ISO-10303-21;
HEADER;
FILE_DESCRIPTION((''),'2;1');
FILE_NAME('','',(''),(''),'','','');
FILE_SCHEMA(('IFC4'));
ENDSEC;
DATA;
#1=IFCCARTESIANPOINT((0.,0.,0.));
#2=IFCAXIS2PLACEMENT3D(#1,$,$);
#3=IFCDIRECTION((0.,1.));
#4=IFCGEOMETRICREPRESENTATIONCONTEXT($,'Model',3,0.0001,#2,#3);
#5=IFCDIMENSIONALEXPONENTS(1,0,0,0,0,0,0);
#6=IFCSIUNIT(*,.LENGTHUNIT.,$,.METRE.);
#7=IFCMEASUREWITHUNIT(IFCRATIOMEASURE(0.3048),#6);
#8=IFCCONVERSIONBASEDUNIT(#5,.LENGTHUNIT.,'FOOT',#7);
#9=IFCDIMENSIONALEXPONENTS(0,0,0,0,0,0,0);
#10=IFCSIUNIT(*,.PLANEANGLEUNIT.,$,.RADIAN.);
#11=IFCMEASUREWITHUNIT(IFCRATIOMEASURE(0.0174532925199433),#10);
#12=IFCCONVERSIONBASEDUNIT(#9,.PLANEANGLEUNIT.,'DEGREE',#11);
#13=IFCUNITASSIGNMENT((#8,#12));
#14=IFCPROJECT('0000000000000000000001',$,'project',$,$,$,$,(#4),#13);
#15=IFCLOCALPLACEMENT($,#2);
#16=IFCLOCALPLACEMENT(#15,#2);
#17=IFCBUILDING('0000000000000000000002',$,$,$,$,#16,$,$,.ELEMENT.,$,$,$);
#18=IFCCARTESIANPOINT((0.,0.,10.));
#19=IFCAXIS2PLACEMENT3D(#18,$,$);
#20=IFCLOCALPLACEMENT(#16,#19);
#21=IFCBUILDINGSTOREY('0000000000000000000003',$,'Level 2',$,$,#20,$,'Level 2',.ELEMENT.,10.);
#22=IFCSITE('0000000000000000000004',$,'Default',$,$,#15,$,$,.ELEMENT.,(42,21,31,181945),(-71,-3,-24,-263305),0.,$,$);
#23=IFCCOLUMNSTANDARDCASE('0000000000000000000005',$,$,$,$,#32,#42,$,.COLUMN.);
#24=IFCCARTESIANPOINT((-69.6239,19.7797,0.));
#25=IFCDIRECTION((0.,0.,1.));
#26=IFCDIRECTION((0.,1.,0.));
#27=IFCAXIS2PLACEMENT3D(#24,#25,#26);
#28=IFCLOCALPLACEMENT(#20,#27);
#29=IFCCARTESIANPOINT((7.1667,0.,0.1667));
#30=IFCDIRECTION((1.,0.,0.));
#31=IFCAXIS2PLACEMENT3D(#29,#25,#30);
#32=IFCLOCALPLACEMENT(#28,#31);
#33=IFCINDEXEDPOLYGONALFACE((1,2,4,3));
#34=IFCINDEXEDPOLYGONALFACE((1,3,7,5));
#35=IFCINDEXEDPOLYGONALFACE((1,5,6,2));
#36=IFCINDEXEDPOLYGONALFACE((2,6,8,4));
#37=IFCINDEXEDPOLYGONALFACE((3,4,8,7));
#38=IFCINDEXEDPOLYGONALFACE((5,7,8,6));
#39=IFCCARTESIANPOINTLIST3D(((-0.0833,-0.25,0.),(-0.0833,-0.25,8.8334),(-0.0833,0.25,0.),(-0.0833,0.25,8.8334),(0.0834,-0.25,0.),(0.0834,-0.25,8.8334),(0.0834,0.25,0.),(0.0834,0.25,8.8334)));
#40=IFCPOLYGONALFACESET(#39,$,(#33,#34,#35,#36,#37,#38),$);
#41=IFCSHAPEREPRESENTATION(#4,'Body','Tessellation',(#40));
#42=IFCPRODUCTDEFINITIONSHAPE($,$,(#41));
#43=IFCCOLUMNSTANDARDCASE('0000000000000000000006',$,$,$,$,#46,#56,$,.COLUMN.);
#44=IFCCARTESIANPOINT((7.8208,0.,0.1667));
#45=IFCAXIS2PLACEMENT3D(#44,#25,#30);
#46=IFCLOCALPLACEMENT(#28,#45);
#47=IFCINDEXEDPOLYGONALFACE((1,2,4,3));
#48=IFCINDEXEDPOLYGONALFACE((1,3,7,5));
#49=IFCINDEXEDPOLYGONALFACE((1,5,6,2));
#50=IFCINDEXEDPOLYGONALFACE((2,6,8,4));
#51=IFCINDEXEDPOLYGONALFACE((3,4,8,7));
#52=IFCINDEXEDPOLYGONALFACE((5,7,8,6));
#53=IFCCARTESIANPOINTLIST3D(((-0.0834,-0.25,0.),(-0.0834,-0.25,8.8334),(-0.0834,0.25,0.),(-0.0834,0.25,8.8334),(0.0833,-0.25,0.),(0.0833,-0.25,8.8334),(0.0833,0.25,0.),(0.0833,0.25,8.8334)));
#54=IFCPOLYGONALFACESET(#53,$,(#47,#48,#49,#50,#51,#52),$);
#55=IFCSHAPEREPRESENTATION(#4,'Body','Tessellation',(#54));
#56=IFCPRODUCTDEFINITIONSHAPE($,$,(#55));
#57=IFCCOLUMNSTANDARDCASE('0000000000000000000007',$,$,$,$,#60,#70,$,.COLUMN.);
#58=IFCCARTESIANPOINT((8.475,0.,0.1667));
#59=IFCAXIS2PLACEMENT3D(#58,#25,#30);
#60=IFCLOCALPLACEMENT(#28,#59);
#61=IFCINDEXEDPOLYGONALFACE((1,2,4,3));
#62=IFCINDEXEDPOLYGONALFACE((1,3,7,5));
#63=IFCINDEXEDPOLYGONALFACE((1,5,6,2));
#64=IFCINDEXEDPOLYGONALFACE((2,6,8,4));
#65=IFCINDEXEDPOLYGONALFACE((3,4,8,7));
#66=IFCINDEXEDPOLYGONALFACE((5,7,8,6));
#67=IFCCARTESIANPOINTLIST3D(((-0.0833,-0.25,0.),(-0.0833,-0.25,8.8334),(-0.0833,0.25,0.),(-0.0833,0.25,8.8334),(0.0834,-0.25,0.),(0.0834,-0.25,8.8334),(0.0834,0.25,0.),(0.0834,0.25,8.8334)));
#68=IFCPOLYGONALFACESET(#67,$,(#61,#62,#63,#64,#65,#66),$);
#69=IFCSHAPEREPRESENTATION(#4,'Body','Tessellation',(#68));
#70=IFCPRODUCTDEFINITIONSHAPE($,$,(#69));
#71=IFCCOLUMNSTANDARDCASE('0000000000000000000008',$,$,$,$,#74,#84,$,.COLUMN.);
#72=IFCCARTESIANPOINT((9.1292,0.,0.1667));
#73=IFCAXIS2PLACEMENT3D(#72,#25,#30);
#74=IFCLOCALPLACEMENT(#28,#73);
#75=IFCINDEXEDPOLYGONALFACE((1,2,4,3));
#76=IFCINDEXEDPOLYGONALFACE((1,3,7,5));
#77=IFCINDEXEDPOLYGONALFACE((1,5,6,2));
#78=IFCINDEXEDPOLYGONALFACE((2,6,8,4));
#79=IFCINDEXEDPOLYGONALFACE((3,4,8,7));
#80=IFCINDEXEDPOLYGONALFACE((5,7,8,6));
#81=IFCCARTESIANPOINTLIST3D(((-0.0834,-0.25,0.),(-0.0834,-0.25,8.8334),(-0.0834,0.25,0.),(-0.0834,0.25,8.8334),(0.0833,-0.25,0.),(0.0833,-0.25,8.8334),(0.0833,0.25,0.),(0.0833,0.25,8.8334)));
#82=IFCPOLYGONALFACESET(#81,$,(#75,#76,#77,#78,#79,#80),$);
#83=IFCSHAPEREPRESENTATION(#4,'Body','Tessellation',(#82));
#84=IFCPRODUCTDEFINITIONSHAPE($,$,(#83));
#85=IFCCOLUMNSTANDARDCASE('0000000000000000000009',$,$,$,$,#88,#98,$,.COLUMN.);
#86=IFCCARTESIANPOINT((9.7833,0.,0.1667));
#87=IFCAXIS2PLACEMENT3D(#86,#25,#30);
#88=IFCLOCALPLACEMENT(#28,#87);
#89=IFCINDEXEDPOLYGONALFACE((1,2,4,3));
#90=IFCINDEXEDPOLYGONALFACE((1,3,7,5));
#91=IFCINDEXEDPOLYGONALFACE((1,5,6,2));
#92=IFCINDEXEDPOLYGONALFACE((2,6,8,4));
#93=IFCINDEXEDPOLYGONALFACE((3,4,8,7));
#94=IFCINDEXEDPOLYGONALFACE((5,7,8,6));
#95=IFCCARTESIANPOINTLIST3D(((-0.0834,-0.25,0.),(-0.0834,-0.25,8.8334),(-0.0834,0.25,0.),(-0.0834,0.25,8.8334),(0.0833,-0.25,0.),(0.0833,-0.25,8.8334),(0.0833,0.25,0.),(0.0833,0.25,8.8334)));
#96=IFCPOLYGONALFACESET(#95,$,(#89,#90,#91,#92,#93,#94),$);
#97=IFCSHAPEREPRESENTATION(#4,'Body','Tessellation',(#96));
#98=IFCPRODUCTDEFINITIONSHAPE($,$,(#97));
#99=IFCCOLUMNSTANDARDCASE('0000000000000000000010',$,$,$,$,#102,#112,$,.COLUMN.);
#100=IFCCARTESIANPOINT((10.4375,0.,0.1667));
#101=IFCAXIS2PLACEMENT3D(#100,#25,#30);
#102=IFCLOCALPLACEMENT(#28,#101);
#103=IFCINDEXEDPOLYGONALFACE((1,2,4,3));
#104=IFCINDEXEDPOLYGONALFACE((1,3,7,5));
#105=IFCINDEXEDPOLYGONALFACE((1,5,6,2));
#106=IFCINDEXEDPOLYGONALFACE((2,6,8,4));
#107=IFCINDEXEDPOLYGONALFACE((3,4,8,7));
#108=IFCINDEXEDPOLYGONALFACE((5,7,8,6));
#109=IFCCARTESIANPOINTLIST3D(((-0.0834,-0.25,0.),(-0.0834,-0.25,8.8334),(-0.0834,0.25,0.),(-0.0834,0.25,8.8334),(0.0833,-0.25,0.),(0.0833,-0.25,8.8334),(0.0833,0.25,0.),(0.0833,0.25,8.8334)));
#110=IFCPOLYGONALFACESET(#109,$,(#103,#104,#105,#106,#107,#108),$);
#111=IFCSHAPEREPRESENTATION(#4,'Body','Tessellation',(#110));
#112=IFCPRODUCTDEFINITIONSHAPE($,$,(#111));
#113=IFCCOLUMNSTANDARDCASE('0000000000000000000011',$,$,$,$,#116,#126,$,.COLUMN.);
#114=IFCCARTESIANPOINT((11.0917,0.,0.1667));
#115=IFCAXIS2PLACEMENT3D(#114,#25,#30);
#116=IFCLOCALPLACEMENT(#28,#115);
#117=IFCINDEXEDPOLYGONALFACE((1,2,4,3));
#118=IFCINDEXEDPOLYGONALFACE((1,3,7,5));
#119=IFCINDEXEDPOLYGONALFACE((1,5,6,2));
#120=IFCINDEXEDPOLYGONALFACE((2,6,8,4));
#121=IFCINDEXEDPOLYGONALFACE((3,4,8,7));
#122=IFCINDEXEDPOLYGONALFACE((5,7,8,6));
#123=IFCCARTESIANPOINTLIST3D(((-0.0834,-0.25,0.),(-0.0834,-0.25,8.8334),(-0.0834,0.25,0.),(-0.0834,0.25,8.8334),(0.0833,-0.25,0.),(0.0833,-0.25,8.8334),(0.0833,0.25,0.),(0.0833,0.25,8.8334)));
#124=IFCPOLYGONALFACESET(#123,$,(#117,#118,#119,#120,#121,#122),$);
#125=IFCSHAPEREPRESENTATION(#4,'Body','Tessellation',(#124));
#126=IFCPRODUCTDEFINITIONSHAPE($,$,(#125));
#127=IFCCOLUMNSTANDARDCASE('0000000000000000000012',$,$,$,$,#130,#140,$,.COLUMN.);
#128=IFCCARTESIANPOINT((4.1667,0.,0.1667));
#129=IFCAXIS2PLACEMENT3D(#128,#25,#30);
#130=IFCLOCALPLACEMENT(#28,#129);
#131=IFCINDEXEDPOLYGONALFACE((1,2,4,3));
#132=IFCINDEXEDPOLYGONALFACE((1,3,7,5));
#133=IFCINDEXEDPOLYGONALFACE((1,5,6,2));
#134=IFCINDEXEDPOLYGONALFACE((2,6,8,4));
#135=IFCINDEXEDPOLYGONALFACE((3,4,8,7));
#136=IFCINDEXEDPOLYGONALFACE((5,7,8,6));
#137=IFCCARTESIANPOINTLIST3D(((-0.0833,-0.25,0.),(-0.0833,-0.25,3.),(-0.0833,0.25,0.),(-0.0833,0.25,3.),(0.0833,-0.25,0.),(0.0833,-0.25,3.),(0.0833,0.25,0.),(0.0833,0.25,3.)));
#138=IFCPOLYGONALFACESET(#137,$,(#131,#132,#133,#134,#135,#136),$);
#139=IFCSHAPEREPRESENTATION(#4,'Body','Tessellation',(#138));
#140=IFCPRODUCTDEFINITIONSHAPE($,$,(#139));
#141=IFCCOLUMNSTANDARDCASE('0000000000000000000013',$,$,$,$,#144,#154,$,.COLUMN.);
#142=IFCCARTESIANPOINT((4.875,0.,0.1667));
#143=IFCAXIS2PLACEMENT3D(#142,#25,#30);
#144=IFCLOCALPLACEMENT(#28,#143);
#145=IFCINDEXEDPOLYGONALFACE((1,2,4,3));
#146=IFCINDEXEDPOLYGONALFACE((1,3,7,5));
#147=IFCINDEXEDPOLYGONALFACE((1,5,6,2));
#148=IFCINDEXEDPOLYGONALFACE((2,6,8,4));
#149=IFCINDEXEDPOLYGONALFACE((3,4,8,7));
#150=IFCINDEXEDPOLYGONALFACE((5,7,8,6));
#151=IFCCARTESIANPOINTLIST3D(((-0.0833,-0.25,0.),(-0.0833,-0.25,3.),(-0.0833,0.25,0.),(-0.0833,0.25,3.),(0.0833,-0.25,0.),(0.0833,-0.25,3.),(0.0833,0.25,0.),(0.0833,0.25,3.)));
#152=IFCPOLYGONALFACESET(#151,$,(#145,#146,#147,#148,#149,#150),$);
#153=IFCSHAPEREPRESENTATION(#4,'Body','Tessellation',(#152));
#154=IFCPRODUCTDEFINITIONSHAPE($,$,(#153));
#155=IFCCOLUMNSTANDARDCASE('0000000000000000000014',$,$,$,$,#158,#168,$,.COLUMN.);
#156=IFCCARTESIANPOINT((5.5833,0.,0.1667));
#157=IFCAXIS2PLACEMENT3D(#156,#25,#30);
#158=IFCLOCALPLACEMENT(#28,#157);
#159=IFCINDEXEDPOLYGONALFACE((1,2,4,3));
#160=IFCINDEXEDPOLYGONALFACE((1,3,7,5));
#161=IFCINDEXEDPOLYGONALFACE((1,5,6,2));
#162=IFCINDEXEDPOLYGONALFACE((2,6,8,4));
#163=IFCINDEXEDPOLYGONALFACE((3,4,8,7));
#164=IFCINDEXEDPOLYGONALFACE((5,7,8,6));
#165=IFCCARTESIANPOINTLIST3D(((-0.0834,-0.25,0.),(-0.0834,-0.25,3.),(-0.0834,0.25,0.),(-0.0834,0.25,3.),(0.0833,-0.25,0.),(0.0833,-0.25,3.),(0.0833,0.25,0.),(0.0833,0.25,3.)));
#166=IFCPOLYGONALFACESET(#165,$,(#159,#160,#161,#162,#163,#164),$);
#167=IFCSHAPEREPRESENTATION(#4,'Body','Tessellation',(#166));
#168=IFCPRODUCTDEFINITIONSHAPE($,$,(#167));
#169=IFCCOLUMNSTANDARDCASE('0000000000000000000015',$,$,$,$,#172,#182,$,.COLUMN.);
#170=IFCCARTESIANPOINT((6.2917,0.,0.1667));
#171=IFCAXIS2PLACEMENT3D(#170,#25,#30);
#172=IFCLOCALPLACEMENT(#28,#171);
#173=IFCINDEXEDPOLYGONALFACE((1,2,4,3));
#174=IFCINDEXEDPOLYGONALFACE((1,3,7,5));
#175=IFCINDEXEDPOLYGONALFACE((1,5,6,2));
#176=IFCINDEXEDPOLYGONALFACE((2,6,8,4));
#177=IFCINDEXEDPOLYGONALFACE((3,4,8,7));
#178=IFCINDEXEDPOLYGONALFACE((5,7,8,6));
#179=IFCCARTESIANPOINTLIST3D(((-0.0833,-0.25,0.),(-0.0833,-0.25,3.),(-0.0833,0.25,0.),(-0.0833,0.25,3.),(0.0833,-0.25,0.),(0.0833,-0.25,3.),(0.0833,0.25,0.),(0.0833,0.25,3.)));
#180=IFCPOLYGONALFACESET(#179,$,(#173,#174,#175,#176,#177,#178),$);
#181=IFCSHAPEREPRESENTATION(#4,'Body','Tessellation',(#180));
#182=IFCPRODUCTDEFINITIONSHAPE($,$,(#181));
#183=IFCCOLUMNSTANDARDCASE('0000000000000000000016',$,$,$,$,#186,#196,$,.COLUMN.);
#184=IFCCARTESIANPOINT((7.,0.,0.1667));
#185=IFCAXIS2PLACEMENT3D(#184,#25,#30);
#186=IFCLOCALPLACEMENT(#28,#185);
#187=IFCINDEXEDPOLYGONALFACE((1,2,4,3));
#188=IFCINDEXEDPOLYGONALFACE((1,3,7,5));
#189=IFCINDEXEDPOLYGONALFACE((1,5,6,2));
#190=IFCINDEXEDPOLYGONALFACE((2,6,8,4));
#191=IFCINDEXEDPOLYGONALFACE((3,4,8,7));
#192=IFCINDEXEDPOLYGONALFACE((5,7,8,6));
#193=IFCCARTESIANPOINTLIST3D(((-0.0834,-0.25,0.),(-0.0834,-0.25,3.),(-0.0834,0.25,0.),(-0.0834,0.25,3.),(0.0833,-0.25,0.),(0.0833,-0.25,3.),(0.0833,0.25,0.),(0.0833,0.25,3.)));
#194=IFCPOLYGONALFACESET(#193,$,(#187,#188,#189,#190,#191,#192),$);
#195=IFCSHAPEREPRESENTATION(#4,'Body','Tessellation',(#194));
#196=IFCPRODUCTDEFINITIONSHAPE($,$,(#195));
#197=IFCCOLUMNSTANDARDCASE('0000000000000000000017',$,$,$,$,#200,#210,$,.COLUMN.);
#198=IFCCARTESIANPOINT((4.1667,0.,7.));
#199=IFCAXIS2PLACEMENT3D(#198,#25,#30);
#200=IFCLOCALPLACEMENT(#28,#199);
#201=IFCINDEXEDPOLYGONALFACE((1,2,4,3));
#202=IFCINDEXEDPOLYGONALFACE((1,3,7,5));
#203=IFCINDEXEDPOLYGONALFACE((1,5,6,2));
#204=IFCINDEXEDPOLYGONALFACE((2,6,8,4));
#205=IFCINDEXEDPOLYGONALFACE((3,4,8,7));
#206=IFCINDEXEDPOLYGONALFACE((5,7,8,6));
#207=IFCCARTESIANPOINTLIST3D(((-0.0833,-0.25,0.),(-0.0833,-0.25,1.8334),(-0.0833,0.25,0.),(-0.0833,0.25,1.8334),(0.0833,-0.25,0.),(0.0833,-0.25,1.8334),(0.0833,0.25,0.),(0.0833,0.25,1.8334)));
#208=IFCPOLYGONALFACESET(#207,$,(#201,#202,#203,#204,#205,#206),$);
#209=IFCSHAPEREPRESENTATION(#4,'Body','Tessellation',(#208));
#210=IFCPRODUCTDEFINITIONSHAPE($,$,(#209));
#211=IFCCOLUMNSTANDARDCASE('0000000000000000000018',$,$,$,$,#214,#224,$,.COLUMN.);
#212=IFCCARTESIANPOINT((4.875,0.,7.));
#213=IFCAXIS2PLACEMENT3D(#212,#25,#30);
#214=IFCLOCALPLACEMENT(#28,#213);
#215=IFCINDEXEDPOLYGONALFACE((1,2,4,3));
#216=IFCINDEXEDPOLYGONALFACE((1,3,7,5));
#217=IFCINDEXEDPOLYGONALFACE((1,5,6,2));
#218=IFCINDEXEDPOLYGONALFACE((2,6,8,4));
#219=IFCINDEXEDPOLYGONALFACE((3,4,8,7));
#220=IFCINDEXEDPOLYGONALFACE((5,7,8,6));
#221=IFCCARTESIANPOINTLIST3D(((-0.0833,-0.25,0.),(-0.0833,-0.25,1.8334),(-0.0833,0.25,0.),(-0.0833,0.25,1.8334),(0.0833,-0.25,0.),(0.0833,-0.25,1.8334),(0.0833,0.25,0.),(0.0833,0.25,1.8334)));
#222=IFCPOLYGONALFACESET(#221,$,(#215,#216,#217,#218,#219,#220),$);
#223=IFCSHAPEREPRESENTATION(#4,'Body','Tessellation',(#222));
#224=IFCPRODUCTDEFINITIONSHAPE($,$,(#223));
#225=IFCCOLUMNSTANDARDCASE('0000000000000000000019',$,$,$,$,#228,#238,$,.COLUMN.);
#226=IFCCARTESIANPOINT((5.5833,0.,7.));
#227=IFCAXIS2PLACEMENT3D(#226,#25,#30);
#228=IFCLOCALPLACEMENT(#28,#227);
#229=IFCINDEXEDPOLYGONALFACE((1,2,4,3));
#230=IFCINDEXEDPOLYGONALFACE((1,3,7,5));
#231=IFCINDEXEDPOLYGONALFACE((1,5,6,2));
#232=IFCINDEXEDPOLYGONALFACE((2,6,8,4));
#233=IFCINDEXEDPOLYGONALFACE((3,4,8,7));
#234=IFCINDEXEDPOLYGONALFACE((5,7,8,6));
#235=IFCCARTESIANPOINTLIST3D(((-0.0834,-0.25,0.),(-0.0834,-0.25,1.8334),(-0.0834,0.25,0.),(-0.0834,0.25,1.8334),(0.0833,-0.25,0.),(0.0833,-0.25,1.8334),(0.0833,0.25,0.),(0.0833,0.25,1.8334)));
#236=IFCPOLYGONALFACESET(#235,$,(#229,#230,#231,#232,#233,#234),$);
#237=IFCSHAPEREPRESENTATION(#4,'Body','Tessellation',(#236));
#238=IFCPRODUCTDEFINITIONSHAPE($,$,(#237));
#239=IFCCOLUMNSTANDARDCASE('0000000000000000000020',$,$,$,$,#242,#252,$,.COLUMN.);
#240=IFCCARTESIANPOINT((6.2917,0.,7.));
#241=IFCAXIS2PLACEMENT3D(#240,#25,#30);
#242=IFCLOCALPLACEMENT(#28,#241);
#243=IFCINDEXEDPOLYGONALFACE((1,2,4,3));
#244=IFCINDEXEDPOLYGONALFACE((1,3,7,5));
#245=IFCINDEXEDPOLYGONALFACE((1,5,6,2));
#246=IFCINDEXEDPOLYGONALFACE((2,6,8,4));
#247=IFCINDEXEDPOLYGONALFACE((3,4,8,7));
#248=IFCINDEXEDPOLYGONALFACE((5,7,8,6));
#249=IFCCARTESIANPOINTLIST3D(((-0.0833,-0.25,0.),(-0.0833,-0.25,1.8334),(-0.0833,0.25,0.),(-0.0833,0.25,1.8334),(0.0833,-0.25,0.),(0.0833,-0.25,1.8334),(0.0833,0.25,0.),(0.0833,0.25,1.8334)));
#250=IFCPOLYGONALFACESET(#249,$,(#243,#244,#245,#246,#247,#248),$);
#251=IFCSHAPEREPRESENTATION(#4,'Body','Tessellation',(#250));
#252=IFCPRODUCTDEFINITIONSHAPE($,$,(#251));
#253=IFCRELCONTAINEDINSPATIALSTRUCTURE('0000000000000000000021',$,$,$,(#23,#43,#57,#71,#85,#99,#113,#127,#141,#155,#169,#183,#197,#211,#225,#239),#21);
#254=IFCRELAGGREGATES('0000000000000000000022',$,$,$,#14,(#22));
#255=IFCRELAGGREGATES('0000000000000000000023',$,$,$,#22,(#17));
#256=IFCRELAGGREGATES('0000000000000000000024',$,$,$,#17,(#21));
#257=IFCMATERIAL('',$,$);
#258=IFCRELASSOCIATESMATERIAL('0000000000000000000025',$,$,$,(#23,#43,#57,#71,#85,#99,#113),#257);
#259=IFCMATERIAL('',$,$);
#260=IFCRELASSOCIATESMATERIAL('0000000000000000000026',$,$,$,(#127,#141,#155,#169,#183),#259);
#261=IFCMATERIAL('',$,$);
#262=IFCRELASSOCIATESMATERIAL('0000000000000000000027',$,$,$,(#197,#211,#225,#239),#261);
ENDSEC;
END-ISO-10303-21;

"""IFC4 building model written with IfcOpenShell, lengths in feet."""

from ifc_helpers import new_model, entity, si_unit, converted_unit, direction, frame, origin, place, context, project, spatial, rectangle, extrude, material, element, save


model = new_model("IFC4")

# Units and contexts
model_context = context("Model", 3, precision=0.0001, world=origin(), true_north=direction((0.0, 1.0)))
ifc_project = project(units=[converted_unit("LENGTHUNIT", "FOOT", entity("IfcRatioMeasure", 0.3048), si_unit("LENGTHUNIT", "METRE"), dimensions=[1, 0, 0, 0, 0, 0, 0]), converted_unit("PLANEANGLEUNIT", "DEGREE", entity("IfcRatioMeasure", 0.0174532925199433), si_unit("PLANEANGLEUNIT", "RADIAN"), dimensions=[0, 0, 0, 0, 0, 0, 0])], contexts=[model_context])

# Site, building, storey
site_placement = place(None, origin())
site = spatial("IfcSite", under=ifc_project, at=site_placement, Name="Default", CompositionType="ELEMENT", RefLatitude=(42, 21, 31, 181945), RefLongitude=(-71, -3, -24, -263305), RefElevation=0.0)
building_placement = place(site_placement, origin())
building = spatial("IfcBuilding", under=site, at=building_placement, CompositionType="ELEMENT")
storey_placement = place(building_placement, frame((0.0, 0.0, 10.0)))
storey = spatial("IfcBuildingStorey", under=building, at=storey_placement, Name="Level 2", LongName="Level 2", CompositionType="ELEMENT", Elevation=10.0)

# Columns
placement_1 = place(storey_placement, frame((-69.6239, 19.7797, 0.0), z_axis=(0.0, 0.0, 1.0), x_axis=(0.0, 1.0, 0.0)))
ifc_material_1 = material(Name="")
for number, where, z_axis, x_axis in (
    (1, (7.1667, 0.0, 0.1667), (0.0, 0.0, 1.0), (1.0, 0.0, 0.0)),
    (2, (7.8208, 0.0, 0.1667), (0.0, 0.0, 1.0), (1.0, 0.0, 0.0)),
    (3, (8.475, 0.0, 0.1667), (0.0, 0.0, 1.0), (1.0, 0.0, 0.0)),
    (4, (9.1292, 0.0, 0.1667), (0.0, 0.0, 1.0), (1.0, 0.0, 0.0)),
    (5, (9.7833, 0.0, 0.1667), (0.0, 0.0, 1.0), (1.0, 0.0, 0.0)),
    (6, (10.4375, 0.0, 0.1667), (0.0, 0.0, 1.0), (1.0, 0.0, 0.0)),
    (7, (11.0917, 0.0, 0.1667), (0.0, 0.0, 1.0), (1.0, 0.0, 0.0)),
):
    element("IfcColumnStandardCase", number, at=place(placement_1, frame(where, z_axis=z_axis, x_axis=x_axis)), inside=storey, material=ifc_material_1, PredefinedType="COLUMN", context=model_context, shape_type="SweptSolid", body=[
        extrude(rectangle(XDim=0.1667, YDim=0.5), origin(), (0.0, 0.0, 1.0), 8.8334),
    ])
ifc_material_2 = material(Name="")
for number, where, z_axis, x_axis in (
    (8, (4.1667, 0.0, 0.1667), (0.0, 0.0, 1.0), (1.0, 0.0, 0.0)),
    (9, (4.875, 0.0, 0.1667), (0.0, 0.0, 1.0), (1.0, 0.0, 0.0)),
    (10, (5.5833, 0.0, 0.1667), (0.0, 0.0, 1.0), (1.0, 0.0, 0.0)),
    (11, (6.2917, 0.0, 0.1667), (0.0, 0.0, 1.0), (1.0, 0.0, 0.0)),
    (12, (7.0, 0.0, 0.1667), (0.0, 0.0, 1.0), (1.0, 0.0, 0.0)),
):
    element("IfcColumnStandardCase", number, at=place(placement_1, frame(where, z_axis=z_axis, x_axis=x_axis)), inside=storey, material=ifc_material_2, PredefinedType="COLUMN", context=model_context, shape_type="SweptSolid", body=[
        extrude(rectangle(XDim=0.1667, YDim=0.5), origin(), (0.0, 0.0, 1.0), 3.0),
    ])
ifc_material_3 = material(Name="")
for number, where, z_axis, x_axis in (
    (13, (4.1667, 0.0, 7.0), (0.0, 0.0, 1.0), (1.0, 0.0, 0.0)),
    (14, (4.875, 0.0, 7.0), (0.0, 0.0, 1.0), (1.0, 0.0, 0.0)),
    (15, (5.5833, 0.0, 7.0), (0.0, 0.0, 1.0), (1.0, 0.0, 0.0)),
    (16, (6.2917, 0.0, 7.0), (0.0, 0.0, 1.0), (1.0, 0.0, 0.0)),
):
    element("IfcColumnStandardCase", number, at=place(placement_1, frame(where, z_axis=z_axis, x_axis=x_axis)), inside=storey, material=ifc_material_3, PredefinedType="COLUMN", context=model_context, shape_type="SweptSolid", body=[
        extrude(rectangle(XDim=0.1667, YDim=0.5), origin(), (0.0, 0.0, 1.0), 1.8334),
    ])

save(model, "model.ifc")
